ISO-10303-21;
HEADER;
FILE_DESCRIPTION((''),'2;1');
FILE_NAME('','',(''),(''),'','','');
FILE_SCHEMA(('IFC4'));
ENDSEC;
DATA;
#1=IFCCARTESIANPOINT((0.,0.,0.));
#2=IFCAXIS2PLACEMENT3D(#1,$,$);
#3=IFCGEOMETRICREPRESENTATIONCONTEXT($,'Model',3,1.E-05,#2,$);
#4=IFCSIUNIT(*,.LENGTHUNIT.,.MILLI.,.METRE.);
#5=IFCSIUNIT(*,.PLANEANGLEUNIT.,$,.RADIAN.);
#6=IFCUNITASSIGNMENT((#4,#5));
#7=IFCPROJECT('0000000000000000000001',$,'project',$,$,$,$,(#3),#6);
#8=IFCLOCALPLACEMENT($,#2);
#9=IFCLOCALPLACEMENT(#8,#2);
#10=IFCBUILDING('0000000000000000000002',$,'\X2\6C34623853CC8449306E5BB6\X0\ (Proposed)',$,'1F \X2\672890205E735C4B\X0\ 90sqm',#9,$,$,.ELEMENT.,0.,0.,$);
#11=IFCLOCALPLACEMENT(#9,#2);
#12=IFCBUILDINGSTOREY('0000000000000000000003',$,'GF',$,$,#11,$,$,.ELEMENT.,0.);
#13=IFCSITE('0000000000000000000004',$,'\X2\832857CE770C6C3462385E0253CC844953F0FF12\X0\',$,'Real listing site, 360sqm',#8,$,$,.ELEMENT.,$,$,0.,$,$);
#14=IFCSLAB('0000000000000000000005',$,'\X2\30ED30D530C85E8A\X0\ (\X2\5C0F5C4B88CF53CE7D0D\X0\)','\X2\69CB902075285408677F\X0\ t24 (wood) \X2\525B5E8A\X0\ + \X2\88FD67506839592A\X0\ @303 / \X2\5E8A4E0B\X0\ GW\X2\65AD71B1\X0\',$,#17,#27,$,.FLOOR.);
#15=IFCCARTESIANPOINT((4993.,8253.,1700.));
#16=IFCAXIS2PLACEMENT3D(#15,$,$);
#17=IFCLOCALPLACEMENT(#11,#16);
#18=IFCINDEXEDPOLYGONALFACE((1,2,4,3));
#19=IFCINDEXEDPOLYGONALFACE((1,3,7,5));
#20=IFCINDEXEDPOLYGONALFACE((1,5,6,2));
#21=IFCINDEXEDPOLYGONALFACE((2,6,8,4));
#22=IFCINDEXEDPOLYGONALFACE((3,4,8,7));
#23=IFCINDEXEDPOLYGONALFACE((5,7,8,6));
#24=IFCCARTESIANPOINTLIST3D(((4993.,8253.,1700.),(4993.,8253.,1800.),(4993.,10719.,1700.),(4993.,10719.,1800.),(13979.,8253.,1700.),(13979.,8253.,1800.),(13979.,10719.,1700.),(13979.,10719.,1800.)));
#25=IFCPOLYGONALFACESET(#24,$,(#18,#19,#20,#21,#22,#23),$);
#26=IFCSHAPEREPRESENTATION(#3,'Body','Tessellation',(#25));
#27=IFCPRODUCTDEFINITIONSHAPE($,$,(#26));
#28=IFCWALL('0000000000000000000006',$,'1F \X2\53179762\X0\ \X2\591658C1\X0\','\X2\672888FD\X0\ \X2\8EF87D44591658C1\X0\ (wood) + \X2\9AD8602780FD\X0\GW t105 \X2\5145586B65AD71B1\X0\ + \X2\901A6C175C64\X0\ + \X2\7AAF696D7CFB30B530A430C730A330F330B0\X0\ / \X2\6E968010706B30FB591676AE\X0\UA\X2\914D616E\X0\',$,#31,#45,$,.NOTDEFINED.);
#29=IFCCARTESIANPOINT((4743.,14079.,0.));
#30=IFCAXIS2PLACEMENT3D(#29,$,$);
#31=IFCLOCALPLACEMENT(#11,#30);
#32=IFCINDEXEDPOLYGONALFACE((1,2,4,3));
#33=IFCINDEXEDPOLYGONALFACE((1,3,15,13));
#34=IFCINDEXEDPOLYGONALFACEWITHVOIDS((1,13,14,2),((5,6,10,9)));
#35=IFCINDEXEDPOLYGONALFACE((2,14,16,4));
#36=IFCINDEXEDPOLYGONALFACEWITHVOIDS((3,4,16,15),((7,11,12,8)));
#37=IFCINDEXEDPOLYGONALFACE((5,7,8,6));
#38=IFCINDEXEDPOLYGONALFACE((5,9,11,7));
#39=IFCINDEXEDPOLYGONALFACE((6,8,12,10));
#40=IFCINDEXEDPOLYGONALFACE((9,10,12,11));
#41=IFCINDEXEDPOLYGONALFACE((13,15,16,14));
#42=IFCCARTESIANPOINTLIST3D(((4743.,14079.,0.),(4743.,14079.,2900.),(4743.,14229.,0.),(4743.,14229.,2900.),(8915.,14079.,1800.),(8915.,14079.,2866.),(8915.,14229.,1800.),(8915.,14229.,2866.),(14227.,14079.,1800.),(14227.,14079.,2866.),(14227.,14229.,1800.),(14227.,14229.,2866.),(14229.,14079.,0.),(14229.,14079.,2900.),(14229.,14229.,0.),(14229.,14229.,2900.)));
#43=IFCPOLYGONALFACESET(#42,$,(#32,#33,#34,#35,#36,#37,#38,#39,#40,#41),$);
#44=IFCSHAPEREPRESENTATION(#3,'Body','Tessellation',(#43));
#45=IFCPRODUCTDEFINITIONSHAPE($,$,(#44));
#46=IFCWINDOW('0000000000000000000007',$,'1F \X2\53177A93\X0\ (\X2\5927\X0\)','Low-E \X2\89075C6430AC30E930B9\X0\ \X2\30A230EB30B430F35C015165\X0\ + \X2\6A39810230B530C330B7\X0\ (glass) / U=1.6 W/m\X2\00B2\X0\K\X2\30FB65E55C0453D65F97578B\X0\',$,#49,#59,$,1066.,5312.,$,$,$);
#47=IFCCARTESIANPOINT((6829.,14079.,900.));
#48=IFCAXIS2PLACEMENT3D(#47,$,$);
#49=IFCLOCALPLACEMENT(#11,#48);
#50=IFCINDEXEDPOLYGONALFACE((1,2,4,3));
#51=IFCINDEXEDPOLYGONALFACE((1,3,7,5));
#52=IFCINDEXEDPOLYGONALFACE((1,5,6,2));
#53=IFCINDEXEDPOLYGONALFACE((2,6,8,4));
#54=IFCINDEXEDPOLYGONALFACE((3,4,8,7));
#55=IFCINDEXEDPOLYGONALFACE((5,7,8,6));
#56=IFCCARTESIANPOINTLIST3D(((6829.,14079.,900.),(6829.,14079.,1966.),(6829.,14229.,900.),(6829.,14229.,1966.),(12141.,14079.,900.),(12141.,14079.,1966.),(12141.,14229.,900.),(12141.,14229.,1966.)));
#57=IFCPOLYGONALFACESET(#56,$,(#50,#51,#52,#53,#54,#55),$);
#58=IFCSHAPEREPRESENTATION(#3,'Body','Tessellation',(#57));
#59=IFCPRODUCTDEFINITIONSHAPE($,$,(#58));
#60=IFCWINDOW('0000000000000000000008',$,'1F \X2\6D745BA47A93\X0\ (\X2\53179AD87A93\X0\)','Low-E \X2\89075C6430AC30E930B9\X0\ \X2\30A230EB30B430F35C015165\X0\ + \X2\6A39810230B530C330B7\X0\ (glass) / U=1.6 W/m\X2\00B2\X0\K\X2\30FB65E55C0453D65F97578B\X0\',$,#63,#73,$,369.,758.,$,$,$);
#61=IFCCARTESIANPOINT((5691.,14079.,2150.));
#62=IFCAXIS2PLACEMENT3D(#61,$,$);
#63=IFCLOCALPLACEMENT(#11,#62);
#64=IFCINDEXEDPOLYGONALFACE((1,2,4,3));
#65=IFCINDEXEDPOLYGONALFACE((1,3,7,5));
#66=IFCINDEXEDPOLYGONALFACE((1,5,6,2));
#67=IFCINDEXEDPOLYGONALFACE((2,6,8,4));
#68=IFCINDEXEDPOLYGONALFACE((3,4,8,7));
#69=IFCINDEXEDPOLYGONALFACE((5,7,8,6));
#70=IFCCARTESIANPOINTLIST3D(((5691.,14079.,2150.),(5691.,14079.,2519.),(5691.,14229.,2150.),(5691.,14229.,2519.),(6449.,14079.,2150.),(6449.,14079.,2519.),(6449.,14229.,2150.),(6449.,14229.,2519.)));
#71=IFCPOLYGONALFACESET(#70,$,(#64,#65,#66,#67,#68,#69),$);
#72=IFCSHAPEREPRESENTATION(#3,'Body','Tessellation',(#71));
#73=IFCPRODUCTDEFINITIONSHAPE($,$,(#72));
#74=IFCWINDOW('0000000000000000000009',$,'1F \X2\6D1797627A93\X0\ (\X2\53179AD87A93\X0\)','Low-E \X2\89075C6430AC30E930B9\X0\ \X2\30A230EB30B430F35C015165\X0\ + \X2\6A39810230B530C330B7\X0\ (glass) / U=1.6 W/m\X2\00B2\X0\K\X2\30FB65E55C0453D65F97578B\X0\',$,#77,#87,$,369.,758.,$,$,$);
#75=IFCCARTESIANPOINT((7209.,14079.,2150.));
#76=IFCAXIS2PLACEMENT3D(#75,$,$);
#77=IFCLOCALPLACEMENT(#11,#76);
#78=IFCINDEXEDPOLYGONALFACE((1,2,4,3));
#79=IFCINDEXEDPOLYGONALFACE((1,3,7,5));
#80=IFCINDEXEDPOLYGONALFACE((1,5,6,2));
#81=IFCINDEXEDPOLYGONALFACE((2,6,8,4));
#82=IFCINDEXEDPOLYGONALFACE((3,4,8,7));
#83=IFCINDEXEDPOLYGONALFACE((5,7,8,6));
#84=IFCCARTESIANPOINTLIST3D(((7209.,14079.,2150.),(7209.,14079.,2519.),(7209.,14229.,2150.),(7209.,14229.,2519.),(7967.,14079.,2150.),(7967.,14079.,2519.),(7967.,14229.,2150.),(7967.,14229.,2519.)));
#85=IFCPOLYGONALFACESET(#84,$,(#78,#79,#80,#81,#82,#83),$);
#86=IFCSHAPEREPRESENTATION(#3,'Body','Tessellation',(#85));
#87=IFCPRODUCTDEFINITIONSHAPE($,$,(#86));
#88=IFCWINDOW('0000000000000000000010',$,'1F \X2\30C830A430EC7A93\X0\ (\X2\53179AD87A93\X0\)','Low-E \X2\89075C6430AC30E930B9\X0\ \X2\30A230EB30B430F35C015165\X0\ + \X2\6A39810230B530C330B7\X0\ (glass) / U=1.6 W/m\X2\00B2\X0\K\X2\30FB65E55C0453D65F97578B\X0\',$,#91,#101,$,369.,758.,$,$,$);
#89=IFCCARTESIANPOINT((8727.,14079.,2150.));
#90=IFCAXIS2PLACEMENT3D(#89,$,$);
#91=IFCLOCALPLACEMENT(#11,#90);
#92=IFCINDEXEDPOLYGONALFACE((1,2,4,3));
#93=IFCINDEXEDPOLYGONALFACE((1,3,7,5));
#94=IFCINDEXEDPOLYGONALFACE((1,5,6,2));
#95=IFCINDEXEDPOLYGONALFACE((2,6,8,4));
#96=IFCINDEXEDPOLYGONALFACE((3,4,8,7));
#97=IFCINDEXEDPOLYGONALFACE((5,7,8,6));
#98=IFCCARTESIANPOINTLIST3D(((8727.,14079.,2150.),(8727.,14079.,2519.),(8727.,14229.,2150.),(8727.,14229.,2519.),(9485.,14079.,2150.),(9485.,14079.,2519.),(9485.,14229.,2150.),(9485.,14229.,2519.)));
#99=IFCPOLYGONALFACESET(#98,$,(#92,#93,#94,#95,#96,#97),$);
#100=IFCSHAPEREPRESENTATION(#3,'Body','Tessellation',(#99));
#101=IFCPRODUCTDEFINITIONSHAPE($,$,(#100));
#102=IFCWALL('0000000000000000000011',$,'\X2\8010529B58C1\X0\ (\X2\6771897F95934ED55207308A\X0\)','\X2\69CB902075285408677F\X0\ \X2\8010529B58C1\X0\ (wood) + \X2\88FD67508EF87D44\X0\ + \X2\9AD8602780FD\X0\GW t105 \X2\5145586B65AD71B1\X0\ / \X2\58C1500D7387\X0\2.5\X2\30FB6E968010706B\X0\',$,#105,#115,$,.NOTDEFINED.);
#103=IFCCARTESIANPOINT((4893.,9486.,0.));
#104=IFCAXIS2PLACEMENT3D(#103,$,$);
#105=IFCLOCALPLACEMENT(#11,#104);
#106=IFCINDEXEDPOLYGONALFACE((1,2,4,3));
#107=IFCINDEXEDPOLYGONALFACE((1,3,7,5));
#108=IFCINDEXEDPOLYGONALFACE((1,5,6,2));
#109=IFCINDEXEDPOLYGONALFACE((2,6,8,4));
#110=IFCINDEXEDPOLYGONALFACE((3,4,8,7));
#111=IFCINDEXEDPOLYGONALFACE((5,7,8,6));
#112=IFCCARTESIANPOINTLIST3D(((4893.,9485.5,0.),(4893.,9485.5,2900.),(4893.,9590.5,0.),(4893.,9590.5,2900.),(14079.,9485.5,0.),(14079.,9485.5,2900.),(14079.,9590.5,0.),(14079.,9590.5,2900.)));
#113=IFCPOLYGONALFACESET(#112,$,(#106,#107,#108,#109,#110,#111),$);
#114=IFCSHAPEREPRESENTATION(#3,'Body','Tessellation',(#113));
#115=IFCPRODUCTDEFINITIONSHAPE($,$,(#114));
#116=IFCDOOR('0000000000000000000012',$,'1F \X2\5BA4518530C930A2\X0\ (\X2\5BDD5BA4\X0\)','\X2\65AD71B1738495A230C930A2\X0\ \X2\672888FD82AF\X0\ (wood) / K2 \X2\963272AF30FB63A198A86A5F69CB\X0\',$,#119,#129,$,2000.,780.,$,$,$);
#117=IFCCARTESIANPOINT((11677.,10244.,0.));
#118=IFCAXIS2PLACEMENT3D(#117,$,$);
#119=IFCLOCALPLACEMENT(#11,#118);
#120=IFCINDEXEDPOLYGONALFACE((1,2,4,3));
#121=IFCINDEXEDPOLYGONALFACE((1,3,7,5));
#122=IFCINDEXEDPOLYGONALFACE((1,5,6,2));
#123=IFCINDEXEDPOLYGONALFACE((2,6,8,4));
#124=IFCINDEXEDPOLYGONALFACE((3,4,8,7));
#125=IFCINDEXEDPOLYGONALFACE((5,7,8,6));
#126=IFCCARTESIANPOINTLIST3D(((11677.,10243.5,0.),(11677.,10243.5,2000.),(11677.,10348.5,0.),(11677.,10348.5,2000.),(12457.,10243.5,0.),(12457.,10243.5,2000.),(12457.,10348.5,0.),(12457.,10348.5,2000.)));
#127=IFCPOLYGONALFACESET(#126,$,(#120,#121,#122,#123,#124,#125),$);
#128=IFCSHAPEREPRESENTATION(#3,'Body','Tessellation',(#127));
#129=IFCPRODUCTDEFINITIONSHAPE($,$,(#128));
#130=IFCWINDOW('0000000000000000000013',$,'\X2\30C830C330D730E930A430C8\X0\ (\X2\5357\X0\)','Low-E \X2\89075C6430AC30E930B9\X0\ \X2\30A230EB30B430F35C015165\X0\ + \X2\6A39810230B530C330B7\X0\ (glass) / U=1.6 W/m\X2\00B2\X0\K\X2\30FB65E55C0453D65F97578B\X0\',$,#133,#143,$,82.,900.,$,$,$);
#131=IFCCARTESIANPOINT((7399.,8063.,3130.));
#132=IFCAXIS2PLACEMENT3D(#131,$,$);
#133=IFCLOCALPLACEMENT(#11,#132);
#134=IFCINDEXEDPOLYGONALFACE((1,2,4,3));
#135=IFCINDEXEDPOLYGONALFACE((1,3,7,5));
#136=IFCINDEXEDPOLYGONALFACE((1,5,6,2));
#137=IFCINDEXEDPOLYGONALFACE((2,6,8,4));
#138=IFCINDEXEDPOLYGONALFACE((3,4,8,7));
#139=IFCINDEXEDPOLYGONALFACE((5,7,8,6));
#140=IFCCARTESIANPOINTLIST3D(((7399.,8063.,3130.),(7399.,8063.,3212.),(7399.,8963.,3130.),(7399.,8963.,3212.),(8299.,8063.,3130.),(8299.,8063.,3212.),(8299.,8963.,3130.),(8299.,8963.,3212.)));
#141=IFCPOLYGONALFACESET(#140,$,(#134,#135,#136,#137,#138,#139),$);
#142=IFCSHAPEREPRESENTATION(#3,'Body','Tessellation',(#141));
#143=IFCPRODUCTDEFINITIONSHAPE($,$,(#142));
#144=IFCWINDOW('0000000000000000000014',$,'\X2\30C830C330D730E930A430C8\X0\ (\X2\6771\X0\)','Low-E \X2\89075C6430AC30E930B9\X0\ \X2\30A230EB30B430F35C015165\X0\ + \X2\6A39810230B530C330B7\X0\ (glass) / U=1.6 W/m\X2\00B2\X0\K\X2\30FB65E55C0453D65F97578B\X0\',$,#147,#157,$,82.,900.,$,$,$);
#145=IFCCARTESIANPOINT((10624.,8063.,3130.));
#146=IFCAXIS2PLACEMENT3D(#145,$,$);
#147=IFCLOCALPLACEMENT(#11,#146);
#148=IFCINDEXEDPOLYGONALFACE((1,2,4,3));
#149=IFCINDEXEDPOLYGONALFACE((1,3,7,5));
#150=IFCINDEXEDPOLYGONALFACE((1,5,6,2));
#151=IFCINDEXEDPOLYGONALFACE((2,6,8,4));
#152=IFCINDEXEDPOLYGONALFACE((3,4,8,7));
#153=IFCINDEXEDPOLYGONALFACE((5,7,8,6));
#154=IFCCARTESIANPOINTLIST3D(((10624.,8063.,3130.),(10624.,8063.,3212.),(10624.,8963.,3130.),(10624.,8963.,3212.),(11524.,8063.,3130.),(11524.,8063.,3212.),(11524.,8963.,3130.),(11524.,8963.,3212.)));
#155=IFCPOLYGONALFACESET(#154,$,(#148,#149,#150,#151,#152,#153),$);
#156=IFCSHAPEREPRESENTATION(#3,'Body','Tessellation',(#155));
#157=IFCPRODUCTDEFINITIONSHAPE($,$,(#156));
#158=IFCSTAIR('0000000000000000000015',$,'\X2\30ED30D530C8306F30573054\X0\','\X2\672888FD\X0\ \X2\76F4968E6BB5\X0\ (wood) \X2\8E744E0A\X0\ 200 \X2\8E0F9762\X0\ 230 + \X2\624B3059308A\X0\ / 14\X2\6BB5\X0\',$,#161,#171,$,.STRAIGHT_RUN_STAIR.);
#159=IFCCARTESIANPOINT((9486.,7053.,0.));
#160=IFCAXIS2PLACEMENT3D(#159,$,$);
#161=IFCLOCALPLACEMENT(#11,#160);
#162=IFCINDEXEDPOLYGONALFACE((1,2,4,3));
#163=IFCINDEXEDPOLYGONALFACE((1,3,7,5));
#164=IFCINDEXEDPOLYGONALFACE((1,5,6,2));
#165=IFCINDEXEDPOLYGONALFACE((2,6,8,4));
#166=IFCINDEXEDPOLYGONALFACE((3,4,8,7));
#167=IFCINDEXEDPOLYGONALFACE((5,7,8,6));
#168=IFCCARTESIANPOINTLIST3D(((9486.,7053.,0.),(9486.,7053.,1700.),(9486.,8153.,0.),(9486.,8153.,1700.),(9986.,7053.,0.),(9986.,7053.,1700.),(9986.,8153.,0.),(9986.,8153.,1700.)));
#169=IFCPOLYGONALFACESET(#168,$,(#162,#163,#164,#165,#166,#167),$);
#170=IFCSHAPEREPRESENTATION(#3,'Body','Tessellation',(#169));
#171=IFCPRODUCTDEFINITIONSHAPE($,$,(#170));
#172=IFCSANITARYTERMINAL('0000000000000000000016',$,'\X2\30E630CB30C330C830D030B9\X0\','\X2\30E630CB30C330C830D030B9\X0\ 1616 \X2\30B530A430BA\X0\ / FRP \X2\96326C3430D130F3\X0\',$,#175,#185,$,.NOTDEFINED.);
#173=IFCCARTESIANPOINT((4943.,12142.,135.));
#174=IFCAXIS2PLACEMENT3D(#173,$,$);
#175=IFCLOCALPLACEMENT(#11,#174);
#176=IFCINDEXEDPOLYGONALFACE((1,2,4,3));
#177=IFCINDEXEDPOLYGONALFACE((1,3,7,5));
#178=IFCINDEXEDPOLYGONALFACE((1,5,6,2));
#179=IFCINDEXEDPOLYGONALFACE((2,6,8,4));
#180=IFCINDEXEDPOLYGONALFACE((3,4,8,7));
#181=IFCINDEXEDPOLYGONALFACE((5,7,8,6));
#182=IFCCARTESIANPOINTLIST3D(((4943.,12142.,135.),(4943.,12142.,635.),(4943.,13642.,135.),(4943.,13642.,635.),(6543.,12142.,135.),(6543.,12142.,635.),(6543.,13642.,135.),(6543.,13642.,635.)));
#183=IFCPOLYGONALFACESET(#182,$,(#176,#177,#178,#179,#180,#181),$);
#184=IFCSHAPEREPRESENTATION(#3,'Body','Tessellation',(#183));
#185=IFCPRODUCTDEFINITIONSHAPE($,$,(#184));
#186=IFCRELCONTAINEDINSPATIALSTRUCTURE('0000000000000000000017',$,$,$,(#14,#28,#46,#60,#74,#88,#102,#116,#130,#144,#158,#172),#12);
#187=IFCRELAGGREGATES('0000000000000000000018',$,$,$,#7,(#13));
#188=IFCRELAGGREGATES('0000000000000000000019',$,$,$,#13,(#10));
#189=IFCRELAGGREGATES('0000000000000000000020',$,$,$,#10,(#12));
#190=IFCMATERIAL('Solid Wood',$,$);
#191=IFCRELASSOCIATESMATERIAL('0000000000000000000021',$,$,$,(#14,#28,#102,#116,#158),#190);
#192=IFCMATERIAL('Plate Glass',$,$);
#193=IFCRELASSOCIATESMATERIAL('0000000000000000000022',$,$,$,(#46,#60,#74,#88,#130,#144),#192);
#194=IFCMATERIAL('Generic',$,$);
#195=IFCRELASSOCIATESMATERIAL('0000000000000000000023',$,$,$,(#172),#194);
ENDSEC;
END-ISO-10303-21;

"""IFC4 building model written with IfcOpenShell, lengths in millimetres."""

from ifc_helpers import new_model, si_unit, frame, frame_2d, origin, place, context, project, spatial, rectangle, extrude, material, element, fill, save


model = new_model("IFC4")

# Units and contexts
model_context = context("Model", 3, precision=1e-05, world=origin())
ifc_project = project(units=[si_unit("LENGTHUNIT", "METRE", prefix="MILLI"), si_unit("PLANEANGLEUNIT", "RADIAN")], contexts=[model_context])

# Site, building, storey
site_placement = place(None, origin())
site = spatial("IfcSite", under=ifc_project, at=site_placement, Name="茨城県水戸市双葉台２", ObjectType="Real listing site, 360sqm", CompositionType="ELEMENT", RefElevation=0.0)
building_placement = place(site_placement, origin())
building = spatial("IfcBuilding", under=site, at=building_placement, Name="水戸双葉の家 (Proposed)", ObjectType="1F 木造平屋 90sqm", CompositionType="ELEMENT", ElevationOfRefHeight=0.0, ElevationOfTerrain=0.0)
storey_placement = place(building_placement, origin())
storey = spatial("IfcBuildingStorey", under=building, at=storey_placement, Name="GF", CompositionType="ELEMENT", Elevation=0.0)

# Slab
ifc_material_1 = material(Name="Solid Wood")
slab_placement = place(storey_placement, frame((4993.0, 8253.0, 1700.0)))
element("IfcSlab", 1, at=slab_placement, inside=storey, material=ifc_material_1, Name="ロフト床 (小屋裏収納)", Description="構造用合板 t24 (wood) 剛床 + 製材根太 @303 / 床下 GW断熱", PredefinedType="FLOOR", context=model_context, shape_type="SweptSolid", body=[
    extrude(rectangle(XDim=8986.0, YDim=2466.0, at=frame_2d((4493.0, 1233.0))), frame((4993.0, 8253.0, 1700.0)), (0.0, 0.0, 1.0), 100.0),
])

# Wall, openings, windows
wall_1_placement = place(storey_placement, frame((4743.0, 14079.0, 0.0)))
wall_1 = element("IfcWall", 2, at=wall_1_placement, inside=storey, material=ifc_material_1, Name="1F 北面 外壁", Description="木製 軸組外壁 (wood) + 高性能GW t105 充填断熱 + 通気層 + 窯業系サイディング / 準耐火・外皮UA配慮", PredefinedType="NOTDEFINED", context=model_context, shape_type="SweptSolid", body=[
    extrude(rectangle(XDim=9486.0, YDim=150.0, at=frame_2d((4743.0, 75.0))), frame((4743.0, 14079.0, 0.0)), (0.0, 0.0, 1.0), 2900.0),
])
opening_1_placement = place(storey_placement, frame((6829.0, 14079.0, 900.0)))
opening_1 = element("IfcOpeningElement", 3, at=opening_1_placement, cuts=wall_1, PredefinedType="NOTDEFINED", context=model_context, shape_type="SweptSolid", body=[
    extrude(rectangle(XDim=5312.0, YDim=150.0, at=frame_2d((2656.0, 75.0))), frame((6829.0, 14079.0, 900.0)), (0.0, 0.0, 1.0), 1066.0),
])
opening_2_placement = place(storey_placement, frame((5691.0, 14079.0, 2150.0)))
opening_2 = element("IfcOpeningElement", 4, at=opening_2_placement, cuts=wall_1, PredefinedType="NOTDEFINED", context=model_context, shape_type="SweptSolid", body=[
    extrude(rectangle(XDim=758.0, YDim=150.0, at=frame_2d((379.0, 75.0))), frame((5691.0, 14079.0, 2150.0)), (0.0, 0.0, 1.0), 369.0),
])
opening_3_placement = place(storey_placement, frame((7209.0, 14079.0, 2150.0)))
opening_3 = element("IfcOpeningElement", 5, at=opening_3_placement, cuts=wall_1, PredefinedType="NOTDEFINED", context=model_context, shape_type="SweptSolid", body=[
    extrude(rectangle(XDim=758.0, YDim=150.0, at=frame_2d((379.0, 75.0))), frame((7209.0, 14079.0, 2150.0)), (0.0, 0.0, 1.0), 369.0),
])
opening_4_placement = place(storey_placement, frame((8727.0, 14079.0, 2150.0)))
opening_4 = element("IfcOpeningElement", 6, at=opening_4_placement, cuts=wall_1, PredefinedType="NOTDEFINED", context=model_context, shape_type="SweptSolid", body=[
    extrude(rectangle(XDim=758.0, YDim=150.0, at=frame_2d((379.0, 75.0))), frame((8727.0, 14079.0, 2150.0)), (0.0, 0.0, 1.0), 369.0),
])
ifc_material_2 = material(Name="Plate Glass")
window_1_placement = place(storey_placement, frame((6829.0, 14079.0, 900.0)))
window_1 = element("IfcWindow", 7, at=window_1_placement, inside=storey, material=ifc_material_2, Name="1F 北窓 (大)", Description="Low-E 複層ガラス アルゴン封入 + 樹脂サッシ (glass) / U=1.6 W/m²K・日射取得型", OverallHeight=1066.0, OverallWidth=5312.0, context=model_context, shape_type="SweptSolid", body=[
    extrude(rectangle(XDim=5312.0, YDim=150.0, at=frame_2d((2656.0, 75.0))), frame((6829.0, 14079.0, 900.0)), (0.0, 0.0, 1.0), 1066.0),
])
fill(opening_1, window_1)
window_2_placement = place(storey_placement, frame((5691.0, 14079.0, 2150.0)))
window_2 = element("IfcWindow", 8, at=window_2_placement, inside=storey, material=ifc_material_2, Name="1F 浴室窓 (北高窓)", Description="Low-E 複層ガラス アルゴン封入 + 樹脂サッシ (glass) / U=1.6 W/m²K・日射取得型", OverallHeight=369.0, OverallWidth=758.0, context=model_context, shape_type="SweptSolid", body=[
    extrude(rectangle(XDim=758.0, YDim=150.0, at=frame_2d((379.0, 75.0))), frame((5691.0, 14079.0, 2150.0)), (0.0, 0.0, 1.0), 369.0),
])
fill(opening_2, window_2)
window_3_placement = place(storey_placement, frame((7209.0, 14079.0, 2150.0)))
window_3 = element("IfcWindow", 9, at=window_3_placement, inside=storey, material=ifc_material_2, Name="1F 洗面窓 (北高窓)", Description="Low-E 複層ガラス アルゴン封入 + 樹脂サッシ (glass) / U=1.6 W/m²K・日射取得型", OverallHeight=369.0, OverallWidth=758.0, context=model_context, shape_type="SweptSolid", body=[
    extrude(rectangle(XDim=758.0, YDim=150.0, at=frame_2d((379.0, 75.0))), frame((7209.0, 14079.0, 2150.0)), (0.0, 0.0, 1.0), 369.0),
])
fill(opening_3, window_3)
window_4_placement = place(storey_placement, frame((8727.0, 14079.0, 2150.0)))
window_4 = element("IfcWindow", 10, at=window_4_placement, inside=storey, material=ifc_material_2, Name="1F トイレ窓 (北高窓)", Description="Low-E 複層ガラス アルゴン封入 + 樹脂サッシ (glass) / U=1.6 W/m²K・日射取得型", OverallHeight=369.0, OverallWidth=758.0, context=model_context, shape_type="SweptSolid", body=[
    extrude(rectangle(XDim=758.0, YDim=150.0, at=frame_2d((379.0, 75.0))), frame((8727.0, 14079.0, 2150.0)), (0.0, 0.0, 1.0), 369.0),
])
fill(opening_4, window_4)

# Wall
wall_2_placement = place(storey_placement, frame((4893.0, 9486.0, 0.0)))
element("IfcWall", 11, at=wall_2_placement, inside=storey, material=ifc_material_1, Name="耐力壁 (東西間仕切り)", Description="構造用合板 耐力壁 (wood) + 製材軸組 + 高性能GW t105 充填断熱 / 壁倍率2.5・準耐火", PredefinedType="NOTDEFINED", context=model_context, shape_type="SweptSolid", body=[
    extrude(rectangle(XDim=9186.0, YDim=105.0, at=frame_2d((4593.0, 52.0))), frame((4893.0, 9486.0, 0.0)), (0.0, 0.0, 1.0), 2900.0),
])

# Door
door_1_placement = place(storey_placement, frame((11677.0, 10244.0, 0.0)))
element("IfcDoor", 12, at=door_1_placement, inside=storey, material=ifc_material_1, Name="1F 室内ドア (寝室)", Description="断熱玄関ドア 木製芯 (wood) / K2 防犯・採風機構", OverallHeight=2000.0, OverallWidth=780.0, context=model_context, shape_type="SweptSolid", body=[
    extrude(rectangle(XDim=780.0, YDim=105.0, at=frame_2d((390.0, 52.0))), frame((11677.0, 10244.0, 0.0)), (0.0, 0.0, 1.0), 2000.0),
])

# Windows
window_5_placement = place(storey_placement, frame((7399.0, 8063.0, 3130.0)))
element("IfcWindow", 13, at=window_5_placement, inside=storey, material=ifc_material_2, Name="トップライト (南)", Description="Low-E 複層ガラス アルゴン封入 + 樹脂サッシ (glass) / U=1.6 W/m²K・日射取得型", OverallHeight=82.0, OverallWidth=900.0, context=model_context, shape_type="SweptSolid", body=[
    extrude(rectangle(XDim=900.0, YDim=900.0, at=frame_2d((450.0, 450.0))), frame((7399.0, 8063.0, 3130.0)), (0.0, 0.0, 1.0), 82.0),
])
window_6_placement = place(storey_placement, frame((10624.0, 8063.0, 3130.0)))
element("IfcWindow", 14, at=window_6_placement, inside=storey, material=ifc_material_2, Name="トップライト (東)", Description="Low-E 複層ガラス アルゴン封入 + 樹脂サッシ (glass) / U=1.6 W/m²K・日射取得型", OverallHeight=82.0, OverallWidth=900.0, context=model_context, shape_type="SweptSolid", body=[
    extrude(rectangle(XDim=900.0, YDim=900.0, at=frame_2d((450.0, 450.0))), frame((10624.0, 8063.0, 3130.0)), (0.0, 0.0, 1.0), 82.0),
])

# Stair
stair_placement = place(storey_placement, frame((9486.0, 7053.0, 0.0)))
element("IfcStair", 15, at=stair_placement, inside=storey, material=ifc_material_1, Name="ロフトはしご", Description="木製 直階段 (wood) 蹴上 200 踏面 230 + 手すり / 14段", PredefinedType="STRAIGHT_RUN_STAIR", context=model_context, shape_type="SweptSolid", body=[
    extrude(rectangle(XDim=500.0, YDim=1100.0, at=frame_2d((250.0, 550.0))), frame((9486.0, 7053.0, 0.0)), (0.0, 0.0, 1.0), 1700.0),
])

# Sanitary terminal
ifc_material_3 = material(Name="Generic")
sanitary_terminal_1_placement = place(storey_placement, frame((4943.0, 12142.0, 135.0)))
element("IfcSanitaryTerminal", 16, at=sanitary_terminal_1_placement, inside=storey, material=ifc_material_3, Name="ユニットバス", Description="ユニットバス 1616 サイズ / FRP 防水パン", PredefinedType="NOTDEFINED", context=model_context, shape_type="SweptSolid", body=[
    extrude(rectangle(XDim=1600.0, YDim=1500.0, at=frame_2d((800.0, 750.0))), frame((4943.0, 12142.0, 135.0)), (0.0, 0.0, 1.0), 500.0),
])

save(model, "model.ifc")
